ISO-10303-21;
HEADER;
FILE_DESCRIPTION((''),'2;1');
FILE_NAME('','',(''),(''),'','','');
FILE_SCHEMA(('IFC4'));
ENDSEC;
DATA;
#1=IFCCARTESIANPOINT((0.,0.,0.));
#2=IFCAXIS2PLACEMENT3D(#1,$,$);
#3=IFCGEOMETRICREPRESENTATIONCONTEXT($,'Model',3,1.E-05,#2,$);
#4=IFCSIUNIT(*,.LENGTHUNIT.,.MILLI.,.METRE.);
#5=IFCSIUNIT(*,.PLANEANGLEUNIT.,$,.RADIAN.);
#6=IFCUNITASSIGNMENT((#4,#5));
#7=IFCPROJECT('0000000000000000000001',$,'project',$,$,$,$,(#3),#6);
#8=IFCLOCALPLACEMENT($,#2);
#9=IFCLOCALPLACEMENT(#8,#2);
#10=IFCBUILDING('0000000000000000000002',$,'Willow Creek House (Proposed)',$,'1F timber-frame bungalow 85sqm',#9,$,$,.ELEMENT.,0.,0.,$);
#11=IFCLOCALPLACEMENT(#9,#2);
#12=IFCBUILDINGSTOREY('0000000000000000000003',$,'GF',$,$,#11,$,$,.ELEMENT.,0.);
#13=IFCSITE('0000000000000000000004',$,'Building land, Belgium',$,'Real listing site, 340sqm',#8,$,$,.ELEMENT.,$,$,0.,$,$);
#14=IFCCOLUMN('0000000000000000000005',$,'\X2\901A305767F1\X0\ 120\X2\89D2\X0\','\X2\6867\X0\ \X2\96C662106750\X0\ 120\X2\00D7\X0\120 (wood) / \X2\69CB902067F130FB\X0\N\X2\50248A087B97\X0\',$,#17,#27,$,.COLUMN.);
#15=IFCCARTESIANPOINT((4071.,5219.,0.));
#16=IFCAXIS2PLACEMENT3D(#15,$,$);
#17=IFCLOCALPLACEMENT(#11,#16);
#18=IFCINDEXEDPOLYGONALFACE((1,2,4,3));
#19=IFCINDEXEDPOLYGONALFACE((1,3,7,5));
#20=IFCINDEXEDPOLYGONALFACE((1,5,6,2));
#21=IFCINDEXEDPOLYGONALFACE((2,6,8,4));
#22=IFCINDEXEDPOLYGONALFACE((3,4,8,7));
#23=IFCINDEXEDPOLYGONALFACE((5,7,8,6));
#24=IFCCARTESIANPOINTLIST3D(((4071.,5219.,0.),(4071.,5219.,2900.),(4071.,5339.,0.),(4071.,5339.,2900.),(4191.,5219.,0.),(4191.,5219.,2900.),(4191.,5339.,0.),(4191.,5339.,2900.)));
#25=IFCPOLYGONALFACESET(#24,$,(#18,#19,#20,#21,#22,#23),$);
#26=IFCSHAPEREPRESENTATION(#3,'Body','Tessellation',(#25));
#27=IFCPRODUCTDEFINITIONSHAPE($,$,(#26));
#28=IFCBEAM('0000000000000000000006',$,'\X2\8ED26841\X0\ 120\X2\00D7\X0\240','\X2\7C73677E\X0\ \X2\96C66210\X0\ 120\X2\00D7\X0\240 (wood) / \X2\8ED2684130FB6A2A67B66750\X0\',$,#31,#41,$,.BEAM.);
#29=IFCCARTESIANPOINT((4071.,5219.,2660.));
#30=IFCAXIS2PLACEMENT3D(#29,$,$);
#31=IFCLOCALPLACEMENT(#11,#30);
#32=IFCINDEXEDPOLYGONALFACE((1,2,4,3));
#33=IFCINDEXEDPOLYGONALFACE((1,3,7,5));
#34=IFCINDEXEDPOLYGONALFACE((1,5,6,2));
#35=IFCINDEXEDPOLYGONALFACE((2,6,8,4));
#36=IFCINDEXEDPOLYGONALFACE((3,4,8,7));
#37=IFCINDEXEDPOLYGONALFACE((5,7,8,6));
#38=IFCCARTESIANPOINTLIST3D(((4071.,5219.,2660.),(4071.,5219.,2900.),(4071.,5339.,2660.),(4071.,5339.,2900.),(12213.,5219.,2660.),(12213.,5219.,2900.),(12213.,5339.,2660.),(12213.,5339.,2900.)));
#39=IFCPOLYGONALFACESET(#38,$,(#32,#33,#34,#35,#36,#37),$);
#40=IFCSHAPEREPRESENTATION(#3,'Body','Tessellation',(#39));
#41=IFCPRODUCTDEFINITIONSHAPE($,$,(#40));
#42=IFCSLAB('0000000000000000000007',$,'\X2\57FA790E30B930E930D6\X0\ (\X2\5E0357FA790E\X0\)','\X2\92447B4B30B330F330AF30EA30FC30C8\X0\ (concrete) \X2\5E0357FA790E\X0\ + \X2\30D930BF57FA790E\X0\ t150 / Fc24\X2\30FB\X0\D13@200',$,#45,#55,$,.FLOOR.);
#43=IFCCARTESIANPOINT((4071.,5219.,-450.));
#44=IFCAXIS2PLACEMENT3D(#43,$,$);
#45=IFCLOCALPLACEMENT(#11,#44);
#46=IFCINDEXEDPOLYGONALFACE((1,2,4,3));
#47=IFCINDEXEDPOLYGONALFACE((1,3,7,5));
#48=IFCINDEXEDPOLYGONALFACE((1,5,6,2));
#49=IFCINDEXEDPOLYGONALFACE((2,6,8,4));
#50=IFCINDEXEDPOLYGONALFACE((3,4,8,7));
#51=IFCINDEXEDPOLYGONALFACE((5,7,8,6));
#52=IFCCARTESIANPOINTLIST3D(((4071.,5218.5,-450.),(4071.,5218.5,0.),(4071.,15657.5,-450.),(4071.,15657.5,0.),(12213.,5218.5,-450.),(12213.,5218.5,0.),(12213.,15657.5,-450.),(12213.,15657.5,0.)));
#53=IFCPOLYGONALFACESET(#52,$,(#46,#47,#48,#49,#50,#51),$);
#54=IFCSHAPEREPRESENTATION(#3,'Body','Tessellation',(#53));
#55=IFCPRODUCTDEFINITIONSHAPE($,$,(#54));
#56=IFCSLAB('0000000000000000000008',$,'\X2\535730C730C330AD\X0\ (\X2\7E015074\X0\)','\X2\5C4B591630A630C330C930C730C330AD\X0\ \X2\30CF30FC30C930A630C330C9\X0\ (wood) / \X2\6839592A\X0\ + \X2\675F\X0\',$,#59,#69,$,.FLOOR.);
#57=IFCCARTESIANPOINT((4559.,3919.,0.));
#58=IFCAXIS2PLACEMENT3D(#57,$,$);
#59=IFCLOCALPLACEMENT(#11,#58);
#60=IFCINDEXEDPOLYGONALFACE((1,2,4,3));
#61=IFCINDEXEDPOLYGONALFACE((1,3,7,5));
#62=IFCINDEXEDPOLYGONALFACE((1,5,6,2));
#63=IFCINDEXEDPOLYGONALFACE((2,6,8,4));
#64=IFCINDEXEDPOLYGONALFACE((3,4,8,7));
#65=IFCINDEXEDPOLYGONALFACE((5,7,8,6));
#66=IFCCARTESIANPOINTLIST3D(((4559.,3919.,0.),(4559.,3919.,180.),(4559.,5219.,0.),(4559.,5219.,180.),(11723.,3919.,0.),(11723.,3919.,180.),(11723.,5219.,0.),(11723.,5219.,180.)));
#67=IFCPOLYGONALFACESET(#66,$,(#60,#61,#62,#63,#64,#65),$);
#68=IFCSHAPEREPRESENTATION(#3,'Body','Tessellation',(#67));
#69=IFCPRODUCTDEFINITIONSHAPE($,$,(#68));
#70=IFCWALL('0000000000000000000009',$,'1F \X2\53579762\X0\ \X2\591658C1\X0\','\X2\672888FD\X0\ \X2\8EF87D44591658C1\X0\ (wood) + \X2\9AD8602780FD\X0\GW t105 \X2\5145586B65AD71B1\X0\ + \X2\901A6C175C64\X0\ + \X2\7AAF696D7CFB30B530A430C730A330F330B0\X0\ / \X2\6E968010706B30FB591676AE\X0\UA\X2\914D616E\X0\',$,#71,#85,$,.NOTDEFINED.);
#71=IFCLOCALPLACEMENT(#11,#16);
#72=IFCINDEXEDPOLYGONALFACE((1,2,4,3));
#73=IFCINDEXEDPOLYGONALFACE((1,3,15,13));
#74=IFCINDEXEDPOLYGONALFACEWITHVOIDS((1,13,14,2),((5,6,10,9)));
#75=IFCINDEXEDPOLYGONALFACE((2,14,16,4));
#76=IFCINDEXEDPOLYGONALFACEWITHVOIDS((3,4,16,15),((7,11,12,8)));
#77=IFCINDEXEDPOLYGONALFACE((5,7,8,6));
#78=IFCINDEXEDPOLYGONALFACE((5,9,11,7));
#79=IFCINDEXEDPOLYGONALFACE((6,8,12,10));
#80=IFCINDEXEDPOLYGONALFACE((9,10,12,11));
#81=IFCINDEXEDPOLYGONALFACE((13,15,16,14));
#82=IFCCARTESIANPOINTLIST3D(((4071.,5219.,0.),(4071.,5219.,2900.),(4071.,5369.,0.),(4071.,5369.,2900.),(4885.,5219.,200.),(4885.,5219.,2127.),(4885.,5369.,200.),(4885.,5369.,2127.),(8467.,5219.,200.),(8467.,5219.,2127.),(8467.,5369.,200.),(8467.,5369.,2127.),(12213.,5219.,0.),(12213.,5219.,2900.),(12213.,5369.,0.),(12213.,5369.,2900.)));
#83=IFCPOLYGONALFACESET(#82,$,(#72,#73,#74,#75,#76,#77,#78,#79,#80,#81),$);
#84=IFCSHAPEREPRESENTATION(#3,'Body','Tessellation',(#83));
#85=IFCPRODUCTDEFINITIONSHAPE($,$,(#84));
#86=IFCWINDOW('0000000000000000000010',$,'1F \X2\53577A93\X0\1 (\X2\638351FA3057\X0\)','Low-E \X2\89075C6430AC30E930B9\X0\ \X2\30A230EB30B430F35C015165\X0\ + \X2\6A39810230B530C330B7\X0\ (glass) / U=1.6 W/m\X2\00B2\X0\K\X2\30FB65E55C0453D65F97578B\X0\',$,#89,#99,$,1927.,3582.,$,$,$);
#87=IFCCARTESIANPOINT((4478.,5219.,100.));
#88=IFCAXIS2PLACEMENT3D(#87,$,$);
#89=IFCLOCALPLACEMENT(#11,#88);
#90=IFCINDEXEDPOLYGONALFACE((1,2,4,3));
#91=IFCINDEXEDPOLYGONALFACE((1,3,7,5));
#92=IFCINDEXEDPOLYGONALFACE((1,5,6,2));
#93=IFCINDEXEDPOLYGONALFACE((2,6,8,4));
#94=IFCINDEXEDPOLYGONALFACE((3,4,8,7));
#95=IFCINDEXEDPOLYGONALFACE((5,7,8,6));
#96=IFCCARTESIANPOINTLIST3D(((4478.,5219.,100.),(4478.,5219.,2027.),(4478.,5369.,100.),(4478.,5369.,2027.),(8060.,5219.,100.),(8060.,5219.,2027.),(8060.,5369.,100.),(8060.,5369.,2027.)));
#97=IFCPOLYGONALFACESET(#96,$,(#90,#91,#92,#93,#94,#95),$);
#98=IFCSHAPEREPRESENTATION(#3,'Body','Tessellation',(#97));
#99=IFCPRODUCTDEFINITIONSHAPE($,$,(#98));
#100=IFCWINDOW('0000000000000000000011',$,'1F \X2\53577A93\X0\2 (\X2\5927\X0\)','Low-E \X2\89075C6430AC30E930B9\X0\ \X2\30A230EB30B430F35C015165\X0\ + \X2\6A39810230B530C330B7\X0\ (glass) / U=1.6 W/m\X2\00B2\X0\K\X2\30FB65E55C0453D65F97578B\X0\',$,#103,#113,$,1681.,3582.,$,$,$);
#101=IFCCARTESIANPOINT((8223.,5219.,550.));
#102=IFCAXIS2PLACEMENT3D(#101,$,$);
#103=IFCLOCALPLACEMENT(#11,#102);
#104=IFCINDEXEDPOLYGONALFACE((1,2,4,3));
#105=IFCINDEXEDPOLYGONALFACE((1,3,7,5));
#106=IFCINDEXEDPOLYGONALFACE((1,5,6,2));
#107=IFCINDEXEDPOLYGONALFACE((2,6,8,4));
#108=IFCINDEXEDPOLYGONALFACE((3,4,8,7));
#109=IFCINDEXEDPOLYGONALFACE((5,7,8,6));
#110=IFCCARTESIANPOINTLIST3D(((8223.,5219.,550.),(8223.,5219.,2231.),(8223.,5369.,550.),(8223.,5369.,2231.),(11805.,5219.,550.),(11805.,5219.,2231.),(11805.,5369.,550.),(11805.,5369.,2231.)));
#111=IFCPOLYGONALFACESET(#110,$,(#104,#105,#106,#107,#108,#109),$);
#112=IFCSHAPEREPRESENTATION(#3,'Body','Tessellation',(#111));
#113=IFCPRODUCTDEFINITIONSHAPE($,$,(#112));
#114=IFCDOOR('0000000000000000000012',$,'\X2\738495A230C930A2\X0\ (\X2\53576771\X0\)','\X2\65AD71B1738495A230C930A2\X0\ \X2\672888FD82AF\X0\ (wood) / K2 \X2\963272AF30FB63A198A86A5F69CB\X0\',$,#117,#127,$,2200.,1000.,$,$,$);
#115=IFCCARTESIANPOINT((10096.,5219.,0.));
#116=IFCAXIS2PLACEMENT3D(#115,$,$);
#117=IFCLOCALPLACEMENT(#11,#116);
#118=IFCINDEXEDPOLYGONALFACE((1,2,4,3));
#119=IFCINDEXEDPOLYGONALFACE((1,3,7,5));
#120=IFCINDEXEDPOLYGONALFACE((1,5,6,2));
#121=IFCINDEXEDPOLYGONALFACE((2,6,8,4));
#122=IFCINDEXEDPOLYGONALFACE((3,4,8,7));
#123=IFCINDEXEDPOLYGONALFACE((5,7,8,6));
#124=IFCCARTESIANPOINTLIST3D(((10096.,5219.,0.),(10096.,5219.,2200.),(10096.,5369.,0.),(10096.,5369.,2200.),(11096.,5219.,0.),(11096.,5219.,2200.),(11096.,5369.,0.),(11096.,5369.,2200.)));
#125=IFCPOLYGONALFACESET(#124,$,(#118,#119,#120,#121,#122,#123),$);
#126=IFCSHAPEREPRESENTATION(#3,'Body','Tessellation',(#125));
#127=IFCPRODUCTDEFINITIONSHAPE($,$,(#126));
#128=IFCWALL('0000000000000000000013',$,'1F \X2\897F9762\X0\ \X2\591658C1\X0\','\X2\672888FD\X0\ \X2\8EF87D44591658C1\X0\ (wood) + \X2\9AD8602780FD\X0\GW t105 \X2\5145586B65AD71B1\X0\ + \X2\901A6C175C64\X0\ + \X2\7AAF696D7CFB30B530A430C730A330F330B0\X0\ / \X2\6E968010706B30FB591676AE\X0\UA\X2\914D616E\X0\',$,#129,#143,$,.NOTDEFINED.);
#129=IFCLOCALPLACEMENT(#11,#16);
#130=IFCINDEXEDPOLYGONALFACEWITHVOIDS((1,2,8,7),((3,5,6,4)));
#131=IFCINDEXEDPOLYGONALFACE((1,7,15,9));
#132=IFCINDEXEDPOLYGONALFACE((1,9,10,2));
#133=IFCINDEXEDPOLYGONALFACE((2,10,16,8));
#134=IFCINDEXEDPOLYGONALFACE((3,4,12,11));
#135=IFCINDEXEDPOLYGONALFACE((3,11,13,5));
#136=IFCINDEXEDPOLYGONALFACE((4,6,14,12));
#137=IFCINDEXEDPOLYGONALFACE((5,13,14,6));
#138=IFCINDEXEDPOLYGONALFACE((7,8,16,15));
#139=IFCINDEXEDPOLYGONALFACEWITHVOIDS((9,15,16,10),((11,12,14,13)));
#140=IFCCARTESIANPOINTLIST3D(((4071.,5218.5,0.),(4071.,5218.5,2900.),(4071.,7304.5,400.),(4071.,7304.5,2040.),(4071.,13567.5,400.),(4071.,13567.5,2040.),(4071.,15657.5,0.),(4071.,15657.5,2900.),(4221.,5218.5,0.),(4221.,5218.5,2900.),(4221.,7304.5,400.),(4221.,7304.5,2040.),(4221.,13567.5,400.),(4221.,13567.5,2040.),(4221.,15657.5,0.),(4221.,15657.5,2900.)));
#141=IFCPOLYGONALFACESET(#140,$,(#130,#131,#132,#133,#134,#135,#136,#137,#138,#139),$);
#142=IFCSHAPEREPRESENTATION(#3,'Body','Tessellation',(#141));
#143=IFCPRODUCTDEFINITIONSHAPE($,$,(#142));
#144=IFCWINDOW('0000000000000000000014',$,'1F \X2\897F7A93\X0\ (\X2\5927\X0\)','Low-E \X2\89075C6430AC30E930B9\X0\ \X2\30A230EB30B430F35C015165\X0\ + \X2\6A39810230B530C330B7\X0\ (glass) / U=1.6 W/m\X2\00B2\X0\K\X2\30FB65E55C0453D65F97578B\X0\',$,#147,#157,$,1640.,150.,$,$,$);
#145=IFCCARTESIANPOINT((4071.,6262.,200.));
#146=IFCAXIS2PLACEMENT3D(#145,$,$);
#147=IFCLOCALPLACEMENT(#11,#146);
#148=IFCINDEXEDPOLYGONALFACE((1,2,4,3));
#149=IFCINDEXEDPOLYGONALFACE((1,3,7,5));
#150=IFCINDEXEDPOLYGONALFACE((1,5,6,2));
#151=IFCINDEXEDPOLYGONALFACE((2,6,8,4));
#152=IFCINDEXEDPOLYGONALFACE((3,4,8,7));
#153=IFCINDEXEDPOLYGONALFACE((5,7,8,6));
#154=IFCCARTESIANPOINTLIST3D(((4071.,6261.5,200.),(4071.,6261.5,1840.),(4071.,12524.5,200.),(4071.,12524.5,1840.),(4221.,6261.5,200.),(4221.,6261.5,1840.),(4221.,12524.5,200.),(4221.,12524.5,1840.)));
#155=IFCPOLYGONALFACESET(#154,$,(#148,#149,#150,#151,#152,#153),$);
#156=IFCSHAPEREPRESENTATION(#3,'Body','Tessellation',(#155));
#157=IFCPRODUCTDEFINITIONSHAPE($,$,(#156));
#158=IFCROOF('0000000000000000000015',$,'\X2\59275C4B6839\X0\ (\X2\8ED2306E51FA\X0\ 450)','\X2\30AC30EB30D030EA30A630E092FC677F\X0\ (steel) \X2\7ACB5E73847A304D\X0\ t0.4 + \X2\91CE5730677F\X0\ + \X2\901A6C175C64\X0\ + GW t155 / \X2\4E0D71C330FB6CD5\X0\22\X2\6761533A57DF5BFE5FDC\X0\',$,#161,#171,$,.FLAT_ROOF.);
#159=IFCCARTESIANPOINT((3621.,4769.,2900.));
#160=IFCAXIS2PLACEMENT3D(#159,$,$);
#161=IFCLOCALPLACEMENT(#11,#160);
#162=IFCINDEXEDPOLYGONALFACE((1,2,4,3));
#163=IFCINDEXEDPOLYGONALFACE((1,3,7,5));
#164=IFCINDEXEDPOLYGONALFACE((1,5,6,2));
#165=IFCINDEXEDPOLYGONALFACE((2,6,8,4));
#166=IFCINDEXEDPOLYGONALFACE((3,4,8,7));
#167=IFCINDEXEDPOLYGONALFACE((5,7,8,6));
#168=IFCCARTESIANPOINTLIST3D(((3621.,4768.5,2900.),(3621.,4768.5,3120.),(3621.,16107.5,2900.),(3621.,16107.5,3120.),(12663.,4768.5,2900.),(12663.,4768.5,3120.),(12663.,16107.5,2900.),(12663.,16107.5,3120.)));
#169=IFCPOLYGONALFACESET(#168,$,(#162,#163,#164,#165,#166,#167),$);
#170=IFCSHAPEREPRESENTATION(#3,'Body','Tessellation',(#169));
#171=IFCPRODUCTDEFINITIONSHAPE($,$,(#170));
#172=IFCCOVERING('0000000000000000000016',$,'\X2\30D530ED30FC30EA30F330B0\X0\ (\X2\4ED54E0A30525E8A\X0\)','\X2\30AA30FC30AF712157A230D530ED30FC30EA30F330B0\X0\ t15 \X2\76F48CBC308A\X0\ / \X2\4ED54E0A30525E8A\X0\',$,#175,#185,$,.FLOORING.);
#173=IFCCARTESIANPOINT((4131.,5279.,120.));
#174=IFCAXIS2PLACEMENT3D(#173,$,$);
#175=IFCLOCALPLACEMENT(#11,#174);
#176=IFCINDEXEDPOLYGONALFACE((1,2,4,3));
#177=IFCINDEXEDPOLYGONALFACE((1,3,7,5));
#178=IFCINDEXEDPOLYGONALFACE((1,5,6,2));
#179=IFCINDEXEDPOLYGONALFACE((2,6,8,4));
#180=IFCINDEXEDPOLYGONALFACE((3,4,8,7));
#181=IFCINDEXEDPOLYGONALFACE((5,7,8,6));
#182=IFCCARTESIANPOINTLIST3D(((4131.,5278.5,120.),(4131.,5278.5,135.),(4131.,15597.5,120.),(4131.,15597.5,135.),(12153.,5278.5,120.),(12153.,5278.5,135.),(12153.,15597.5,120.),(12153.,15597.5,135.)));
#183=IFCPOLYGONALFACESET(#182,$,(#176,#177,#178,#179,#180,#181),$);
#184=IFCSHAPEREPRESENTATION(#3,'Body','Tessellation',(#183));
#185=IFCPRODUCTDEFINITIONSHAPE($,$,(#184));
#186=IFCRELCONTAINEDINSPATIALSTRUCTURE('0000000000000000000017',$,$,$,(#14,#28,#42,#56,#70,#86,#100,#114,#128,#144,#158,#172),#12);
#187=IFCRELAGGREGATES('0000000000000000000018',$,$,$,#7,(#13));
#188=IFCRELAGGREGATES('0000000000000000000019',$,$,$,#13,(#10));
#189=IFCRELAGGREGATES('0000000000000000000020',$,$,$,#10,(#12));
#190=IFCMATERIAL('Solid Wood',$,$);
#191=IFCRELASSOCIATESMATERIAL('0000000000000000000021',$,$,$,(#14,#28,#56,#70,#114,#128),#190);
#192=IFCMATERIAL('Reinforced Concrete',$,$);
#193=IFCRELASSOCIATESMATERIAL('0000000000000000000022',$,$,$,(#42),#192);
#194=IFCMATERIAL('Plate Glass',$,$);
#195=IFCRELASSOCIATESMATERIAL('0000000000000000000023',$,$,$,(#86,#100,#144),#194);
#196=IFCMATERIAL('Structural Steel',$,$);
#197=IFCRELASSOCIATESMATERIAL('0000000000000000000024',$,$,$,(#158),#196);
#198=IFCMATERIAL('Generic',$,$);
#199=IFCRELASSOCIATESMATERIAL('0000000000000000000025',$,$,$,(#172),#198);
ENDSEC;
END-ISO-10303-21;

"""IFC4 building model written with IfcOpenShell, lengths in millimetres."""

from ifc_helpers import new_model, si_unit, frame, frame_2d, origin, place, context, project, spatial, rectangle, extrude, material, element, fill, save


model = new_model("IFC4")

# Units and contexts
model_context = context("Model", 3, precision=1e-05, world=origin())
ifc_project = project(units=[si_unit("LENGTHUNIT", "METRE", prefix="MILLI"), si_unit("PLANEANGLEUNIT", "RADIAN")], contexts=[model_context])

# Site, building, storey
site_placement = place(None, origin())
site = spatial("IfcSite", under=ifc_project, at=site_placement, Name="Building land, Belgium", ObjectType="Real listing site, 340sqm", CompositionType="ELEMENT", RefElevation=0.0)
building_placement = place(site_placement, origin())
building = spatial("IfcBuilding", under=site, at=building_placement, Name="Willow Creek House (Proposed)", ObjectType="1F timber-frame bungalow 85sqm", CompositionType="ELEMENT", ElevationOfRefHeight=0.0, ElevationOfTerrain=0.0)
storey_placement = place(building_placement, origin())
storey = spatial("IfcBuildingStorey", under=building, at=storey_placement, Name="GF", CompositionType="ELEMENT", Elevation=0.0)

# Column
ifc_material_1 = material(Name="Solid Wood")
column_1_placement = place(storey_placement, frame((4071.0, 5219.0, 0.0)))
element("IfcColumn", 1, at=column_1_placement, inside=storey, material=ifc_material_1, Name="通し柱 120角", Description="桧 集成材 120×120 (wood) / 構造柱・N値計算", PredefinedType="COLUMN", context=model_context, shape_type="SweptSolid", body=[
    extrude(rectangle(XDim=120.0, YDim=120.0, at=frame_2d((60.0, 60.0))), frame((4071.0, 5219.0, 0.0)), (0.0, 0.0, 1.0), 2900.0),
])

# Beam
beam_1_placement = place(storey_placement, frame((4071.0, 5219.0, 2660.0)))
element("IfcBeam", 2, at=beam_1_placement, inside=storey, material=ifc_material_1, Name="軒桁 120×240", Description="米松 集成 120×240 (wood) / 軒桁・横架材", PredefinedType="BEAM", context=model_context, shape_type="SweptSolid", body=[
    extrude(rectangle(XDim=8142.0, YDim=120.0, at=frame_2d((4071.0, 60.0))), frame((4071.0, 5219.0, 2660.0)), (0.0, 0.0, 1.0), 240.0),
])

# Slabs
ifc_material_2 = material(Name="Reinforced Concrete")
slab_1_placement = place(storey_placement, frame((4071.0, 5219.0, -450.0)))
element("IfcSlab", 3, at=slab_1_placement, inside=storey, material=ifc_material_2, Name="基礎スラブ (布基礎)", Description="鉄筋コンクリート (concrete) 布基礎 + ベタ基礎 t150 / Fc24・D13@200", PredefinedType="FLOOR", context=model_context, shape_type="SweptSolid", body=[
    extrude(rectangle(XDim=8142.0, YDim=10439.0, at=frame_2d((4071.0, 5219.0))), frame((4071.0, 5219.0, -450.0)), (0.0, 0.0, 1.0), 450.0),
])
slab_2_placement = place(storey_placement, frame((4559.0, 3919.0, 0.0)))
element("IfcSlab", 4, at=slab_2_placement, inside=storey, material=ifc_material_1, Name="南デッキ (縁側)", Description="屋外ウッドデッキ ハードウッド (wood) / 根太 + 束", PredefinedType="FLOOR", context=model_context, shape_type="SweptSolid", body=[
    extrude(rectangle(XDim=7164.0, YDim=1300.0, at=frame_2d((3582.0, 650.0))), frame((4559.0, 3919.0, 0.0)), (0.0, 0.0, 1.0), 180.0),
])

# Wall, openings, windows, door
wall_1_placement = place(storey_placement, frame((4071.0, 5219.0, 0.0)))
wall_1 = element("IfcWall", 5, at=wall_1_placement, inside=storey, material=ifc_material_1, Name="1F 南面 外壁", Description="木製 軸組外壁 (wood) + 高性能GW t105 充填断熱 + 通気層 + 窯業系サイディング / 準耐火・外皮UA配慮", PredefinedType="NOTDEFINED", context=model_context, shape_type="SweptSolid", body=[
    extrude(rectangle(XDim=8142.0, YDim=150.0, at=frame_2d((4071.0, 75.0))), frame((4071.0, 5219.0, 0.0)), (0.0, 0.0, 1.0), 2900.0),
])
opening_1_placement = place(storey_placement, frame((4478.0, 5219.0, 100.0)))
opening_1 = element("IfcOpeningElement", 6, at=opening_1_placement, cuts=wall_1, PredefinedType="NOTDEFINED", context=model_context, shape_type="SweptSolid", body=[
    extrude(rectangle(XDim=3582.0, YDim=150.0, at=frame_2d((1791.0, 75.0))), frame((4478.0, 5219.0, 100.0)), (0.0, 0.0, 1.0), 1927.0),
])
opening_2_placement = place(storey_placement, frame((8223.0, 5219.0, 550.0)))
opening_2 = element("IfcOpeningElement", 7, at=opening_2_placement, cuts=wall_1, PredefinedType="NOTDEFINED", context=model_context, shape_type="SweptSolid", body=[
    extrude(rectangle(XDim=3582.0, YDim=150.0, at=frame_2d((1791.0, 75.0))), frame((8223.0, 5219.0, 550.0)), (0.0, 0.0, 1.0), 1681.0),
])
opening_3_placement = place(storey_placement, frame((10096.0, 5219.0, 0.0)))
opening_3 = element("IfcOpeningElement", 8, at=opening_3_placement, cuts=wall_1, PredefinedType="NOTDEFINED", context=model_context, shape_type="SweptSolid", body=[
    extrude(rectangle(XDim=1000.0, YDim=150.0, at=frame_2d((500.0, 75.0))), frame((10096.0, 5219.0, 0.0)), (0.0, 0.0, 1.0), 2200.0),
])
ifc_material_3 = material(Name="Plate Glass")
window_1_placement = place(storey_placement, frame((4478.0, 5219.0, 100.0)))
window_1 = element("IfcWindow", 9, at=window_1_placement, inside=storey, material=ifc_material_3, Name="1F 南窓1 (掃出し)", Description="Low-E 複層ガラス アルゴン封入 + 樹脂サッシ (glass) / U=1.6 W/m²K・日射取得型", OverallHeight=1927.0, OverallWidth=3582.0, context=model_context, shape_type="SweptSolid", body=[
    extrude(rectangle(XDim=3582.0, YDim=150.0, at=frame_2d((1791.0, 75.0))), frame((4478.0, 5219.0, 100.0)), (0.0, 0.0, 1.0), 1927.0),
])
fill(opening_1, window_1)
window_2_placement = place(storey_placement, frame((8223.0, 5219.0, 550.0)))
window_2 = element("IfcWindow", 10, at=window_2_placement, inside=storey, material=ifc_material_3, Name="1F 南窓2 (大)", Description="Low-E 複層ガラス アルゴン封入 + 樹脂サッシ (glass) / U=1.6 W/m²K・日射取得型", OverallHeight=1681.0, OverallWidth=3582.0, context=model_context, shape_type="SweptSolid", body=[
    extrude(rectangle(XDim=3582.0, YDim=150.0, at=frame_2d((1791.0, 75.0))), frame((8223.0, 5219.0, 550.0)), (0.0, 0.0, 1.0), 1681.0),
])
fill(opening_2, window_2)
door_placement = place(storey_placement, frame((10096.0, 5219.0, 0.0)))
door = element("IfcDoor", 11, at=door_placement, inside=storey, material=ifc_material_1, Name="玄関ドア (南東)", Description="断熱玄関ドア 木製芯 (wood) / K2 防犯・採風機構", OverallHeight=2200.0, OverallWidth=1000.0, context=model_context, shape_type="SweptSolid", body=[
    extrude(rectangle(XDim=1000.0, YDim=150.0, at=frame_2d((500.0, 75.0))), frame((10096.0, 5219.0, 0.0)), (0.0, 0.0, 1.0), 2200.0),
])
fill(opening_3, door)

# Wall, opening, window
wall_2_placement = place(storey_placement, frame((4071.0, 5219.0, 0.0)))
wall_2 = element("IfcWall", 12, at=wall_2_placement, inside=storey, material=ifc_material_1, Name="1F 西面 外壁", Description="木製 軸組外壁 (wood) + 高性能GW t105 充填断熱 + 通気層 + 窯業系サイディング / 準耐火・外皮UA配慮", PredefinedType="NOTDEFINED", context=model_context, shape_type="SweptSolid", body=[
    extrude(rectangle(XDim=150.0, YDim=10439.0, at=frame_2d((75.0, 5219.0))), frame((4071.0, 5219.0, 0.0)), (0.0, 0.0, 1.0), 2900.0),
])
opening_4_placement = place(storey_placement, frame((4071.0, 6262.0, 200.0)))
opening_4 = element("IfcOpeningElement", 13, at=opening_4_placement, cuts=wall_2, PredefinedType="NOTDEFINED", context=model_context, shape_type="SweptSolid", body=[
    extrude(rectangle(XDim=150.0, YDim=6263.0, at=frame_2d((75.0, 3131.0))), frame((4071.0, 6262.0, 200.0)), (0.0, 0.0, 1.0), 1640.0),
])
window_3_placement = place(storey_placement, frame((4071.0, 6262.0, 200.0)))
window_3 = element("IfcWindow", 14, at=window_3_placement, inside=storey, material=ifc_material_3, Name="1F 西窓 (大)", Description="Low-E 複層ガラス アルゴン封入 + 樹脂サッシ (glass) / U=1.6 W/m²K・日射取得型", OverallHeight=1640.0, OverallWidth=150.0, context=model_context, shape_type="SweptSolid", body=[
    extrude(rectangle(XDim=150.0, YDim=6263.0, at=frame_2d((75.0, 3131.0))), frame((4071.0, 6262.0, 200.0)), (0.0, 0.0, 1.0), 1640.0),
])
fill(opening_4, window_3)

# Roof
ifc_material_4 = material(Name="Structural Steel")
roof_placement = place(storey_placement, frame((3621.0, 4769.0, 2900.0)))
element("IfcRoof", 15, at=roof_placement, inside=storey, material=ifc_material_4, Name="大屋根 (軒の出 450)", Description="ガルバリウム鋼板 (steel) 立平葺き t0.4 + 野地板 + 通気層 + GW t155 / 不燃・法22条区域対応", PredefinedType="FLAT_ROOF", context=model_context, shape_type="SweptSolid", body=[
    extrude(rectangle(XDim=9042.0, YDim=11339.0, at=frame_2d((4521.0, 5669.0))), frame((3621.0, 4769.0, 2900.0)), (0.0, 0.0, 1.0), 220.0),
])

# Covering
ifc_material_5 = material(Name="Generic")
covering_1_placement = place(storey_placement, frame((4131.0, 5279.0, 120.0)))
element("IfcCovering", 16, at=covering_1_placement, inside=storey, material=ifc_material_5, Name="フローリング (仕上げ床)", Description="オーク無垢フローリング t15 直貼り / 仕上げ床", PredefinedType="FLOORING", context=model_context, shape_type="SweptSolid", body=[
    extrude(rectangle(XDim=8022.0, YDim=10319.0, at=frame_2d((4011.0, 5159.0))), frame((4131.0, 5279.0, 120.0)), (0.0, 0.0, 1.0), 15.0),
])

save(model, "model.ifc")
